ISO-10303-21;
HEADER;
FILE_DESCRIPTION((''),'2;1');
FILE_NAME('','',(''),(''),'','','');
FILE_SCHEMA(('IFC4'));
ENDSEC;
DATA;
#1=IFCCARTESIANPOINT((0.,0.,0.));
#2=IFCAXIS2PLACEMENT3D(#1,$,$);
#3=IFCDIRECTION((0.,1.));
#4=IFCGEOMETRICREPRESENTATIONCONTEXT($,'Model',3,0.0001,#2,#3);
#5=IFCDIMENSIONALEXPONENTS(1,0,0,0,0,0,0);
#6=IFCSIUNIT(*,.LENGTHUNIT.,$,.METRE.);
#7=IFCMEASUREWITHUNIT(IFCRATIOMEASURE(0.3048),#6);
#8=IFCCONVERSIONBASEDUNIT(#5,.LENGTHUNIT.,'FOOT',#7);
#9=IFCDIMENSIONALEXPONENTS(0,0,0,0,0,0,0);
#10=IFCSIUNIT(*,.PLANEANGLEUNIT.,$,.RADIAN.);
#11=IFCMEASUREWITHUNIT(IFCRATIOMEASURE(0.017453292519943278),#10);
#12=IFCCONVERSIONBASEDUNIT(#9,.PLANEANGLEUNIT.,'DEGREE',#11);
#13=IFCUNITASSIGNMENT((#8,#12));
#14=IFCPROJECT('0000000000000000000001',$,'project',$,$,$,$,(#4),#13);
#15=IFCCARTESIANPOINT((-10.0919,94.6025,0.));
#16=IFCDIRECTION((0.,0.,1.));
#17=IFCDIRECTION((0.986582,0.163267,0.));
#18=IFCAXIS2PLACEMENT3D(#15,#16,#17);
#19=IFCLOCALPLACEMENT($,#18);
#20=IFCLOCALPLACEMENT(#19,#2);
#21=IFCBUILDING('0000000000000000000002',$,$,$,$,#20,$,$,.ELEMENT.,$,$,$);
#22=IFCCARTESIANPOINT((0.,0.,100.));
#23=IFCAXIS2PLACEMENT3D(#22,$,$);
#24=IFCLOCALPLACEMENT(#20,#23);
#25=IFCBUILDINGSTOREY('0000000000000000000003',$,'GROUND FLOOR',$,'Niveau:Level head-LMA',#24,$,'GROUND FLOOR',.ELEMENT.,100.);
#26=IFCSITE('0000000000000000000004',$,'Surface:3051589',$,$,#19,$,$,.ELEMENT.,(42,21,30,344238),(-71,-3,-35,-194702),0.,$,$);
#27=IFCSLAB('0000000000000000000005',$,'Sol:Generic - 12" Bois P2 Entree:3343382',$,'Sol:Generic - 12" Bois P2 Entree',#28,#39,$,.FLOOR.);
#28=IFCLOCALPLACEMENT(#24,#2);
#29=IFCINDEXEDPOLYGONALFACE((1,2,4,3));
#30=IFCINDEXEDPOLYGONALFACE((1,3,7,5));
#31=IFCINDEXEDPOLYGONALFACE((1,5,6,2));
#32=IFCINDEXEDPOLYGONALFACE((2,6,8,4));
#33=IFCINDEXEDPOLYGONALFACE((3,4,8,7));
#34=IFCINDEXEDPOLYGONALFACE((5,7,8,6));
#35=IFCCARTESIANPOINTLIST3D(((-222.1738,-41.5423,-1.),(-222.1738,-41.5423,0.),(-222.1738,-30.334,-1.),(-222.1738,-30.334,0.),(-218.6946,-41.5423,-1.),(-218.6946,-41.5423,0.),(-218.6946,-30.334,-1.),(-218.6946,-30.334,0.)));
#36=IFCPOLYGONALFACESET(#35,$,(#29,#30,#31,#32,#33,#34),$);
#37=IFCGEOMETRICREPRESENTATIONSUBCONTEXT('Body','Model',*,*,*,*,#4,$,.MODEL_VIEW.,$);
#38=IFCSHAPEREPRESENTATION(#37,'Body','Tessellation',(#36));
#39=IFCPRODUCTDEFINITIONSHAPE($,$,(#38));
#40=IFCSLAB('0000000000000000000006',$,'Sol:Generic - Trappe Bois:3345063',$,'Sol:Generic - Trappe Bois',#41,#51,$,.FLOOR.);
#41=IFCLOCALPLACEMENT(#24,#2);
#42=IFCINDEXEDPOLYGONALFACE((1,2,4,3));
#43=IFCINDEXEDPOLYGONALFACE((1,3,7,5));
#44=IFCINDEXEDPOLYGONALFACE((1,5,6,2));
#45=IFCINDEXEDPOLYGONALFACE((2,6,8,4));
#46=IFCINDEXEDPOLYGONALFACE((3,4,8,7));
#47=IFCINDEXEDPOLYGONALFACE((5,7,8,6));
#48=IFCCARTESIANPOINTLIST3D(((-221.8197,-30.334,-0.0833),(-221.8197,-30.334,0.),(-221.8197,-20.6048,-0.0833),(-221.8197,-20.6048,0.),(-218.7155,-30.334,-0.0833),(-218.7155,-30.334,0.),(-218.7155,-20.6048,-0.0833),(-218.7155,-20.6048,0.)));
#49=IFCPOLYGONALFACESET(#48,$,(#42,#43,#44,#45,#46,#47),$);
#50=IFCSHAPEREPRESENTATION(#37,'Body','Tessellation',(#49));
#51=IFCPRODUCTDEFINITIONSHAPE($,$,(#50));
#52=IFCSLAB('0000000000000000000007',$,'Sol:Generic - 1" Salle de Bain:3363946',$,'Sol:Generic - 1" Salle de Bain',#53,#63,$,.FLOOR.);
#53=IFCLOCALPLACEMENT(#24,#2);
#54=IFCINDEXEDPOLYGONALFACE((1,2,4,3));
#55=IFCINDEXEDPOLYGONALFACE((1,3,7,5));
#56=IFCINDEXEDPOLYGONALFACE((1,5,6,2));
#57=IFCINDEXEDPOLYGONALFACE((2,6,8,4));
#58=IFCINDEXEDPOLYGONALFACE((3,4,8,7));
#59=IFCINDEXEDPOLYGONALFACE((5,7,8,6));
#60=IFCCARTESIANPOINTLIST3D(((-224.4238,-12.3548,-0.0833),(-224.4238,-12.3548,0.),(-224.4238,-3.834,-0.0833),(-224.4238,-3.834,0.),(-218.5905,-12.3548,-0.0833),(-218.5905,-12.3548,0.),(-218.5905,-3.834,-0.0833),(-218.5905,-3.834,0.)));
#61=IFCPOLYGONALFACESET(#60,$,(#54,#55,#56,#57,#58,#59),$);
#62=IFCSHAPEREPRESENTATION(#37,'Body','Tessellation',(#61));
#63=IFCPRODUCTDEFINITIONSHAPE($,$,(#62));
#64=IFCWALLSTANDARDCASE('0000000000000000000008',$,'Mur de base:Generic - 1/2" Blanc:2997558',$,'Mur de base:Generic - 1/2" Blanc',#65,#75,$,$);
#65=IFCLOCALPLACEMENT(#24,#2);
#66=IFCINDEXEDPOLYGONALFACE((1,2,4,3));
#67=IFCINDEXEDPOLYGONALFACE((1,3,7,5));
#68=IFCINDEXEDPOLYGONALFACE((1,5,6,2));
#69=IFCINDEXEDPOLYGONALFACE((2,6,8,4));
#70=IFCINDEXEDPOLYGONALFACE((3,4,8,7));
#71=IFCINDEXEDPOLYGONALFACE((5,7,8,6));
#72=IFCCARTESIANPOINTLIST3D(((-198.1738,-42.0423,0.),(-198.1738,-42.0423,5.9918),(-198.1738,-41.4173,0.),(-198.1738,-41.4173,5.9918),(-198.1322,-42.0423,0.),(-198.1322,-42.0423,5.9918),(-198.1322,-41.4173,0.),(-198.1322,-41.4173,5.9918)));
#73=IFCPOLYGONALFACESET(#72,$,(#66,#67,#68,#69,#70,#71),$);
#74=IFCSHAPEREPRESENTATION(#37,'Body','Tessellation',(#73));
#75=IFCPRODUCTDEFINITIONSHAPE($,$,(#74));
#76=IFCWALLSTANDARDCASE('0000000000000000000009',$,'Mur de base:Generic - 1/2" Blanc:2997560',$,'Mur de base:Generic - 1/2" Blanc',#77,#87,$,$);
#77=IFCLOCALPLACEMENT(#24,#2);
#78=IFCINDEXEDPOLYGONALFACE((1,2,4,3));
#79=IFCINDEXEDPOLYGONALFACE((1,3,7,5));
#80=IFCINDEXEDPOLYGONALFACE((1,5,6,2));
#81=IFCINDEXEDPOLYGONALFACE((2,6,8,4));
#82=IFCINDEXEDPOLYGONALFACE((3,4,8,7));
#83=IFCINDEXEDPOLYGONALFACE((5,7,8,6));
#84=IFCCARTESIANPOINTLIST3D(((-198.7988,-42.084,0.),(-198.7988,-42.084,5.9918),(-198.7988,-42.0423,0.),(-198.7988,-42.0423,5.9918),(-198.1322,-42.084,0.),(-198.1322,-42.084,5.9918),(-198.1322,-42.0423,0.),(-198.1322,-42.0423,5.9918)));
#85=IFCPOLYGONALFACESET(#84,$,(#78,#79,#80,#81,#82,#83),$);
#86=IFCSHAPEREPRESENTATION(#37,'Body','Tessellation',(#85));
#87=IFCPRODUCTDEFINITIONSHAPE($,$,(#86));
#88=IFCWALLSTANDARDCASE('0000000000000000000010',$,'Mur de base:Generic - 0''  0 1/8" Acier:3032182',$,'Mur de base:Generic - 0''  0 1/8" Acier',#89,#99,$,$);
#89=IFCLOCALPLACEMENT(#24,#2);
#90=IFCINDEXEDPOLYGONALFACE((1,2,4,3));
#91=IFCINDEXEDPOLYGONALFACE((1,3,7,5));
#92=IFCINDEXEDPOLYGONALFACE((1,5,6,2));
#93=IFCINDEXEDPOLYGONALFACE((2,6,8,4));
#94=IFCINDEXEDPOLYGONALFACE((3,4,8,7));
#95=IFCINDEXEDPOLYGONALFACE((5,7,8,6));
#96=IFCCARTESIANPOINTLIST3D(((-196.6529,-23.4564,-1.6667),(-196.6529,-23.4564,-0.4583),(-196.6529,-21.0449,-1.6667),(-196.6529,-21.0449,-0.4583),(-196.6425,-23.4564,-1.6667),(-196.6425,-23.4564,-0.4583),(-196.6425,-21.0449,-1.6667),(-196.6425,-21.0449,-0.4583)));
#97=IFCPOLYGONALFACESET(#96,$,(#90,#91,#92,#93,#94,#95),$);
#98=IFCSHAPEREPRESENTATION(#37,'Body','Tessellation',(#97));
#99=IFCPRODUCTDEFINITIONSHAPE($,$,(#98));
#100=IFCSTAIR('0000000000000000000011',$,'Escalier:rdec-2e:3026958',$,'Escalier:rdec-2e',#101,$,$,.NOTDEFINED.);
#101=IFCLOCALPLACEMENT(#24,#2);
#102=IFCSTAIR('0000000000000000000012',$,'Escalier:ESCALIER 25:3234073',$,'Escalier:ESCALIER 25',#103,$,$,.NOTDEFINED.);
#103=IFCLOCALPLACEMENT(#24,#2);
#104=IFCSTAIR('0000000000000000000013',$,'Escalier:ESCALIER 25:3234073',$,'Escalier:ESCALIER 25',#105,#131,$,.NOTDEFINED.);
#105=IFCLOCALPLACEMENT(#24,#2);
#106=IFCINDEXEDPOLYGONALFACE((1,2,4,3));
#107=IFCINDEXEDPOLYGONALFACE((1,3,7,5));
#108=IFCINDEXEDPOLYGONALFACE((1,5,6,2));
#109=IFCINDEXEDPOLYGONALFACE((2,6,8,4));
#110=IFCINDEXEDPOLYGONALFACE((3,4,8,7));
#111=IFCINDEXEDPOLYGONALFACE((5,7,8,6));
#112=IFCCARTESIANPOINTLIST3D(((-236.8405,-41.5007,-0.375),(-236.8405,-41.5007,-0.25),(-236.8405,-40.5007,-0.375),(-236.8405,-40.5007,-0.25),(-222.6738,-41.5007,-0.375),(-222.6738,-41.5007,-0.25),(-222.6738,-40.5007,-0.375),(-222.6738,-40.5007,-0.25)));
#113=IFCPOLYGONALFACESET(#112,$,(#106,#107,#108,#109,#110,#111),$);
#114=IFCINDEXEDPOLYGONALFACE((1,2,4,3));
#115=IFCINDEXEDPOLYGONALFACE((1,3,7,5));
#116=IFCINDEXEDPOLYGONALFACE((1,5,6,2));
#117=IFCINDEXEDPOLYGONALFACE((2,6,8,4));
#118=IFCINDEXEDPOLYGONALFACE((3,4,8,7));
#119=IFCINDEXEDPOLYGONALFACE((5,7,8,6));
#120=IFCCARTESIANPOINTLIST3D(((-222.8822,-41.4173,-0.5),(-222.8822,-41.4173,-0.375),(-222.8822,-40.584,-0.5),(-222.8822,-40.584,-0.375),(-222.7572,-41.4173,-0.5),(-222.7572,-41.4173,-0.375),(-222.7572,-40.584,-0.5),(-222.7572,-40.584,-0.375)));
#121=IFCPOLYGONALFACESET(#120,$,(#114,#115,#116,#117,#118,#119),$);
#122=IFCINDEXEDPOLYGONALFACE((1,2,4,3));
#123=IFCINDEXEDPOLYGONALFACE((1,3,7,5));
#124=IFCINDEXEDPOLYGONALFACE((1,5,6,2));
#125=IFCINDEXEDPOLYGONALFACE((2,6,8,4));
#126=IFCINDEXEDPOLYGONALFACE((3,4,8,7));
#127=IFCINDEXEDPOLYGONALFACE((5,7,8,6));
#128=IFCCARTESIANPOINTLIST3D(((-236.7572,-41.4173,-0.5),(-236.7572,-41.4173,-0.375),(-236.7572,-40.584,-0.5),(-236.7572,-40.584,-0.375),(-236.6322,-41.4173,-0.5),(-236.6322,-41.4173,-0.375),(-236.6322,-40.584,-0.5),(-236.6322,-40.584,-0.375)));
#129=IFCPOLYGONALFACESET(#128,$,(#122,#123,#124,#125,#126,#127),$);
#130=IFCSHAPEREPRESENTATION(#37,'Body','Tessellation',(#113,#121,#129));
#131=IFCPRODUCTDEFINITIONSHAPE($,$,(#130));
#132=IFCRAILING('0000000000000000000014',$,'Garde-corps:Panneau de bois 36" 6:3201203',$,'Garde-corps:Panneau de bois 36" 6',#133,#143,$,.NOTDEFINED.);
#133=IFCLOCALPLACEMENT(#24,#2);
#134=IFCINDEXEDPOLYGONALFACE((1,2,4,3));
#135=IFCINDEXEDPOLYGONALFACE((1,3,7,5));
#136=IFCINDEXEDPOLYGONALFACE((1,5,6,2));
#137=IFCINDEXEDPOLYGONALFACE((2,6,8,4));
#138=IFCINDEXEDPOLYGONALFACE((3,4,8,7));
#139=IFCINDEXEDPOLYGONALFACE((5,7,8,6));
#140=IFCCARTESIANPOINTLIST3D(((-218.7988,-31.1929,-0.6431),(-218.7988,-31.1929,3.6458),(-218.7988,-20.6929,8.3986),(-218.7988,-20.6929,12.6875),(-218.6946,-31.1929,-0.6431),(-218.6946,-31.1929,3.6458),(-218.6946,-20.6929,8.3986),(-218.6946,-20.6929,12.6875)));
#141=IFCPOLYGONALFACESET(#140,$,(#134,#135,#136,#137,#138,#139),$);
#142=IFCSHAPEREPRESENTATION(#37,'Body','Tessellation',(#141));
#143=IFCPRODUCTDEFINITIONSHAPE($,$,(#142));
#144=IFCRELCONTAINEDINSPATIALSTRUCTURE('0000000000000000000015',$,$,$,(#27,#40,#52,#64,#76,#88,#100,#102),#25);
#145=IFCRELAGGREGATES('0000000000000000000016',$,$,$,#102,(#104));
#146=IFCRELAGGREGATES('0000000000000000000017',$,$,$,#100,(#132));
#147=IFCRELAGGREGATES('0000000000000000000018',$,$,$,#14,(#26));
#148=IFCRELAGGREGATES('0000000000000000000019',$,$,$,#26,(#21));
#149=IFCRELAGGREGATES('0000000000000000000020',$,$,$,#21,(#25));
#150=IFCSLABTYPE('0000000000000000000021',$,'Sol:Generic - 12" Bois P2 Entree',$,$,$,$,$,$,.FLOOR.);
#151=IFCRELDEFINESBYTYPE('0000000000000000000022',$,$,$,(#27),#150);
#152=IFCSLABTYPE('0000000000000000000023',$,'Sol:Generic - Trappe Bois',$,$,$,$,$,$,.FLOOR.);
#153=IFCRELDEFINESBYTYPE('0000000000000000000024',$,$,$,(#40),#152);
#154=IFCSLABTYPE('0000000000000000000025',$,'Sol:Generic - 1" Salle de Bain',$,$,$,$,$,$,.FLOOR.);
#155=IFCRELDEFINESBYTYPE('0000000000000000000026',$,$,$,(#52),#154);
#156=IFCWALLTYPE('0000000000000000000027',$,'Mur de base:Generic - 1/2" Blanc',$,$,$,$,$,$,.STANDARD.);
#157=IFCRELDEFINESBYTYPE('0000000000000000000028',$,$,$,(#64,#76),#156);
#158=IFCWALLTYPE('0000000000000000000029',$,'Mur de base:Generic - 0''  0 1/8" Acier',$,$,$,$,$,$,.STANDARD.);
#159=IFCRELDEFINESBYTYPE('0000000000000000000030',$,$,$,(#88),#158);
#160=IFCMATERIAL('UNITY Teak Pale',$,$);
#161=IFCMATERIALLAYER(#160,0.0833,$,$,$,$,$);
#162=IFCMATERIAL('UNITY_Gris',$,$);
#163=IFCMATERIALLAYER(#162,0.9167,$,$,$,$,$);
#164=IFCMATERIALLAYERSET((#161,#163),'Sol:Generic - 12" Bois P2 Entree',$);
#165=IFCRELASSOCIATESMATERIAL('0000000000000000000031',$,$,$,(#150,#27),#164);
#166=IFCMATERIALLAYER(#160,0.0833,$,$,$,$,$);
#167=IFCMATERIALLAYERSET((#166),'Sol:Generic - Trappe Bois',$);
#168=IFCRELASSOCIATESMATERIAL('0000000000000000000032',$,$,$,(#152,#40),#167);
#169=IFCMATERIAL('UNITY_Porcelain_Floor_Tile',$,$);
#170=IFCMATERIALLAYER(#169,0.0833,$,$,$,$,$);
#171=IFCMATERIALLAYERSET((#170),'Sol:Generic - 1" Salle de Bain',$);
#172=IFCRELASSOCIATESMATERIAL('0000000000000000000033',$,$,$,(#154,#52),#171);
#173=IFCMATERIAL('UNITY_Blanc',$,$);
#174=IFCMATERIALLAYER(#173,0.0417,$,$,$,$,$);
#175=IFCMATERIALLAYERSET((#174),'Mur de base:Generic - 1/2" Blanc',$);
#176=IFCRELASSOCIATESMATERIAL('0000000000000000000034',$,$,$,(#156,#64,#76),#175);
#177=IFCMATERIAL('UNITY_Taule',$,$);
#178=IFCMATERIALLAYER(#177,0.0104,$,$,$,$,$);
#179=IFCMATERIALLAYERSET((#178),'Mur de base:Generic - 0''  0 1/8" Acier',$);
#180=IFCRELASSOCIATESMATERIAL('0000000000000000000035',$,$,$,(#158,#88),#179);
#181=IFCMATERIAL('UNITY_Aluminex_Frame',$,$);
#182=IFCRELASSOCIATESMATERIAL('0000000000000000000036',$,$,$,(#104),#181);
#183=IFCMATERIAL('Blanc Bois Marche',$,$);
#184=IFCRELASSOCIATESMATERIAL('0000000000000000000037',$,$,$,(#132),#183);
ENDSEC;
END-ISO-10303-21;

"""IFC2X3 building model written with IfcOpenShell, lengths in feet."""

from ifc_helpers import new_model, entity, si_unit, converted_unit, direction, frame, frame_2d, origin, place, context, subcontext, project, spatial, polyline, rectangle, outline, extrude, clip, bounded_halfspace, material, layer, layer_set, layer_usage, type_object, element, aggregate, save


model = new_model("IFC2X3")

# Units and contexts
model_context = context("Model", 3, precision=0.0001, world=origin(), true_north=direction((0.0, 1.0)))
body_context = subcontext(model_context, "Body", "Model", "MODEL_VIEW")
ifc_project = project(units=[converted_unit("LENGTHUNIT", "FOOT", entity("IfcRatioMeasure", 0.3048), si_unit("LENGTHUNIT", "METRE"), dimensions=[1, 0, 0, 0, 0, 0, 0]), converted_unit("PLANEANGLEUNIT", "DEGREE", entity("IfcRatioMeasure", 0.017453292519943278), si_unit("PLANEANGLEUNIT", "RADIAN"), dimensions=[0, 0, 0, 0, 0, 0, 0])], contexts=[model_context])

# Site, building, storey
site_placement = place(None, frame((-10.0919, 94.6025, 0.0), z_axis=(0.0, 0.0, 1.0), x_axis=(0.986582, 0.163267, 0.0)))
site = spatial("IfcSite", under=ifc_project, at=site_placement, Name="Surface:3051589", CompositionType="ELEMENT", RefLatitude=(42, 21, 30, 344238), RefLongitude=(-71, -3, -35, -194702), RefElevation=0.0)
building_placement = place(site_placement, origin())
building = spatial("IfcBuilding", under=site, at=building_placement, CompositionType="ELEMENT")
storey_placement = place(building_placement, frame((0.0, 0.0, 100.0)))
storey = spatial("IfcBuildingStorey", under=building, at=storey_placement, Name="GROUND FLOOR", ObjectType="Niveau:Level head-LMA", LongName="GROUND FLOOR", CompositionType="ELEMENT", Elevation=100.0)

# Slabs
ifc_material_1 = material(Name="UNITY_Gris")
ifc_material_2 = material(Name="UNITY Teak Pale")
ifc_layer_1 = layer(ifc_material_2, 0.0833)
ifc_layer_2 = layer(ifc_material_1, 0.9167)
ifc_layer_set_1 = layer_set([ifc_layer_1, ifc_layer_2], Name="Sol:Generic - 12\" Bois P2 Entree")
ifc_layer_usage_1 = layer_usage(ifc_layer_set_1, "AXIS3", "POSITIVE", 0.0)
slab_type_1 = type_object("IfcSlabType", Name="Sol:Generic - 12\" Bois P2 Entree", PredefinedType="FLOOR", material=ifc_layer_set_1)
slab_1_placement = place(storey_placement, origin())
element("IfcSlab", 1, at=slab_1_placement, inside=storey, type_object=slab_type_1, material=ifc_layer_usage_1, Name="Sol:Generic - 12\" Bois P2 Entree:3343382", ObjectType="Sol:Generic - 12\" Bois P2 Entree", PredefinedType="FLOOR", context=body_context, shape_type="SweptSolid", body=[
    extrude(rectangle(XDim=11.2083, YDim=3.4792, at=frame_2d((0.0, 0.0), x_axis=(1.0, 0.0))), frame((-220.4342, -35.9382, 0.0), z_axis=(0.0, 0.0, -1.0), x_axis=(0.0, 1.0, 0.0)), (0.0, 0.0, 1.0), 1.0),
])
ifc_layer_3 = layer(ifc_material_2, 0.0833)
ifc_layer_set_2 = layer_set([ifc_layer_3], Name="Sol:Generic - Trappe Bois")
ifc_layer_usage_2 = layer_usage(ifc_layer_set_2, "AXIS3", "POSITIVE", 0.0)
slab_type_2 = type_object("IfcSlabType", Name="Sol:Generic - Trappe Bois", PredefinedType="FLOOR", material=ifc_layer_set_2)
slab_2_placement = place(storey_placement, origin())
element("IfcSlab", 2, at=slab_2_placement, inside=storey, type_object=slab_type_2, material=ifc_layer_usage_2, Name="Sol:Generic - Trappe Bois:3345063", ObjectType="Sol:Generic - Trappe Bois", PredefinedType="FLOOR", context=body_context, shape_type="SweptSolid", body=[
    extrude(rectangle(XDim=9.7292, YDim=3.1042, at=frame_2d((0.0, 0.0), x_axis=(1.0, 0.0))), frame((-220.2676, -25.4694, 0.0), z_axis=(0.0, 0.0, -1.0), x_axis=(0.0, 1.0, 0.0)), (0.0, 0.0, 1.0), 0.0833),
])
ifc_material_3 = material(Name="UNITY_Porcelain_Floor_Tile")
ifc_layer_4 = layer(ifc_material_3, 0.0833)
ifc_layer_set_3 = layer_set([ifc_layer_4], Name="Sol:Generic - 1\" Salle de Bain")
ifc_layer_usage_3 = layer_usage(ifc_layer_set_3, "AXIS3", "POSITIVE", 0.0)
slab_type_3 = type_object("IfcSlabType", Name="Sol:Generic - 1\" Salle de Bain", PredefinedType="FLOOR", material=ifc_layer_set_3)
slab_3_placement = place(storey_placement, origin())
element("IfcSlab", 3, at=slab_3_placement, inside=storey, type_object=slab_type_3, material=ifc_layer_usage_3, Name="Sol:Generic - 1\" Salle de Bain:3363946", ObjectType="Sol:Generic - 1\" Salle de Bain", PredefinedType="FLOOR", context=body_context, shape_type="SweptSolid", body=[
    extrude(rectangle(XDim=8.5208, YDim=5.8333, at=frame_2d((0.0, 0.0), x_axis=(1.0, 0.0))), frame((-221.5072, -8.0944, 0.0), z_axis=(0.0, 0.0, -1.0), x_axis=(0.0, 1.0, 0.0)), (0.0, 0.0, 1.0), 0.0833),
])

# Walls
ifc_material_4 = material(Name="UNITY_Blanc")
ifc_layer_5 = layer(ifc_material_4, 0.0417)
ifc_layer_set_4 = layer_set([ifc_layer_5], Name="Mur de base:Generic - 1/2\" Blanc")
ifc_layer_usage_4 = layer_usage(ifc_layer_set_4, "AXIS2", "NEGATIVE", 0.0208)
wall_type_1 = type_object("IfcWallType", Name="Mur de base:Generic - 1/2\" Blanc", PredefinedType="STANDARD", material=ifc_layer_set_4)
wall_1_placement = place(storey_placement, frame((-198.153, -41.4173, 0.0), z_axis=(0.0, 0.0, 1.0), x_axis=(0.0, -1.0, 0.0)))
element("IfcWallStandardCase", 4, at=wall_1_placement, inside=storey, type_object=wall_type_1, material=ifc_layer_usage_4, Name="Mur de base:Generic - 1/2\" Blanc:2997558", ObjectType="Mur de base:Generic - 1/2\" Blanc", context=body_context, shape_type="Clipping", body=[
    clip(extrude(rectangle(XDim=0.625, YDim=0.0417, at=frame_2d((0.3125, 0.0), x_axis=(-1.0, 0.0))), origin(), (0.0, 0.0, 1.0), 5.9918), bounded_halfspace(frame((0.0, -0.0208, 9.9623), z_axis=(0.0, 0.721387, 0.692532), x_axis=(-1.0, 0.0, 0.0)), False, frame((0.0, -0.0208, 9.9623)), polyline([(0.0, 0.0), (0.625, 0.0), (0.625, 0.0417), (0.0, 0.0417), (0.0, 0.0)]))),
])
ifc_layer_usage_5 = layer_usage(ifc_layer_set_4, "AXIS2", "NEGATIVE", 0.0208)
wall_2_placement = place(storey_placement, frame((-198.1322, -42.0632, 0.0), z_axis=(0.0, 0.0, 1.0), x_axis=(-1.0, 0.0, 0.0)))
element("IfcWallStandardCase", 5, at=wall_2_placement, inside=storey, type_object=wall_type_1, material=ifc_layer_usage_5, Name="Mur de base:Generic - 1/2\" Blanc:2997560", ObjectType="Mur de base:Generic - 1/2\" Blanc", context=body_context, shape_type="Clipping", body=[
    clip(extrude(rectangle(XDim=0.6667, YDim=0.0417, at=frame_2d((0.3333, 0.0), x_axis=(-1.0, 0.0))), origin(), (0.0, 0.0, 1.0), 5.9918), bounded_halfspace(frame((0.0, -0.0208, 9.9189), z_axis=(-0.721387, 0.0, 0.692532), x_axis=(0.0, -1.0, 0.0)), False, frame((0.0, -0.0208, 9.9189)), polyline([(0.0, 0.0), (0.0417, 0.0), (0.6667, 0.0), (0.6667, 0.0417), (0.0, 0.0417), (0.0, 0.0)]))),
])
ifc_material_5 = material(Name="UNITY_Taule")
ifc_layer_6 = layer(ifc_material_5, 0.0104)
ifc_layer_set_5 = layer_set([ifc_layer_6], Name="Mur de base:Generic - 0'  0 1/8\" Acier")
ifc_layer_usage_6 = layer_usage(ifc_layer_set_5, "AXIS2", "NEGATIVE", 0.0052)
wall_type_2 = type_object("IfcWallType", Name="Mur de base:Generic - 0'  0 1/8\" Acier", PredefinedType="STANDARD", material=ifc_layer_set_5)
wall_3_placement = place(storey_placement, frame((-196.6477, -23.4564, -1.6667), z_axis=(0.0, 0.0, 1.0), x_axis=(0.0, 1.0, 0.0)))
element("IfcWallStandardCase", 6, at=wall_3_placement, inside=storey, type_object=wall_type_2, material=ifc_layer_usage_6, Name="Mur de base:Generic - 0'  0 1/8\" Acier:3032182", ObjectType="Mur de base:Generic - 0'  0 1/8\" Acier", context=body_context, shape_type="SweptSolid", body=[
    extrude(rectangle(XDim=2.4115, YDim=0.0104, at=frame_2d((1.2057, 0.0), x_axis=(-1.0, 0.0))), origin(), (0.0, 0.0, 1.0), 1.2083),
])

# Stairs
stair_1_placement = place(storey_placement, origin())
stair_1 = element("IfcStair", 7, at=stair_1_placement, inside=storey, Name="Escalier:rdec-2e:3026958", ObjectType="Escalier:rdec-2e", ShapeType="NOTDEFINED")
stair_2_placement = place(storey_placement, origin())
stair_2 = element("IfcStair", 8, at=stair_2_placement, inside=storey, Name="Escalier:ESCALIER 25:3234073", ObjectType="Escalier:ESCALIER 25", ShapeType="NOTDEFINED")
ifc_material_6 = material(Name="UNITY_Aluminex_Frame")
stair_3_placement = place(stair_2_placement, origin())
stair_3 = element("IfcStair", 9, at=stair_3_placement, material=ifc_material_6, Name="Escalier:ESCALIER 25:3234073", ObjectType="Escalier:ESCALIER 25", ShapeType="NOTDEFINED", context=body_context, shape_type="SweptSolid", body=[
    extrude(rectangle(XDim=1.0, YDim=14.1667, at=frame_2d((0.0, 0.0), x_axis=(1.0, 0.0))), frame((-229.7572, -41.0007, -0.375), z_axis=(0.0, 0.0, 1.0), x_axis=(0.0, -1.0, 0.0)), (0.0, 0.0, 1.0), 0.125),
    extrude(rectangle(XDim=0.8333, YDim=0.125, at=frame_2d((0.0, 0.0), x_axis=(1.0, 0.0))), frame((-222.8197, -41.0007, -0.5), z_axis=(0.0, 0.0, 1.0), x_axis=(0.0, -1.0, 0.0)), (0.0, 0.0, 1.0), 0.125),
    extrude(rectangle(XDim=0.8333, YDim=0.125, at=frame_2d((0.0, 0.0), x_axis=(1.0, 0.0))), frame((-236.6947, -41.0007, -0.5), z_axis=(0.0, 0.0, 1.0), x_axis=(0.0, -1.0, 0.0)), (0.0, 0.0, 1.0), 0.125),
])
aggregate(stair_2, [stair_3])

# Railing
ifc_material_7 = material(Name="Blanc Bois Marche")
railing_placement = place(stair_1_placement, frame((0.0, 0.0, 9.3333)))
railing = element("IfcRailing", 10, at=railing_placement, material=ifc_material_7, Name="Garde-corps:Panneau de bois 36\" 6:3201203", ObjectType="Garde-corps:Panneau de bois 36\" 6", PredefinedType="NOTDEFINED", context=body_context, shape_type="SweptSolid", body=[
    extrude(outline(polyline([(-8.3275, -1.625), (5.5289, -1.625), (8.3275, 1.625), (-5.5289, 1.625), (-8.3275, -1.625)])), frame((-218.7988, -25.9429, -3.3111), z_axis=(1.0, 0.0, 0.0), x_axis=(0.0, -0.757769, -0.652523)), (0.0, 0.0, 1.0), 0.1042),
])
aggregate(stair_1, [railing])

save(model, "model.ifc")
